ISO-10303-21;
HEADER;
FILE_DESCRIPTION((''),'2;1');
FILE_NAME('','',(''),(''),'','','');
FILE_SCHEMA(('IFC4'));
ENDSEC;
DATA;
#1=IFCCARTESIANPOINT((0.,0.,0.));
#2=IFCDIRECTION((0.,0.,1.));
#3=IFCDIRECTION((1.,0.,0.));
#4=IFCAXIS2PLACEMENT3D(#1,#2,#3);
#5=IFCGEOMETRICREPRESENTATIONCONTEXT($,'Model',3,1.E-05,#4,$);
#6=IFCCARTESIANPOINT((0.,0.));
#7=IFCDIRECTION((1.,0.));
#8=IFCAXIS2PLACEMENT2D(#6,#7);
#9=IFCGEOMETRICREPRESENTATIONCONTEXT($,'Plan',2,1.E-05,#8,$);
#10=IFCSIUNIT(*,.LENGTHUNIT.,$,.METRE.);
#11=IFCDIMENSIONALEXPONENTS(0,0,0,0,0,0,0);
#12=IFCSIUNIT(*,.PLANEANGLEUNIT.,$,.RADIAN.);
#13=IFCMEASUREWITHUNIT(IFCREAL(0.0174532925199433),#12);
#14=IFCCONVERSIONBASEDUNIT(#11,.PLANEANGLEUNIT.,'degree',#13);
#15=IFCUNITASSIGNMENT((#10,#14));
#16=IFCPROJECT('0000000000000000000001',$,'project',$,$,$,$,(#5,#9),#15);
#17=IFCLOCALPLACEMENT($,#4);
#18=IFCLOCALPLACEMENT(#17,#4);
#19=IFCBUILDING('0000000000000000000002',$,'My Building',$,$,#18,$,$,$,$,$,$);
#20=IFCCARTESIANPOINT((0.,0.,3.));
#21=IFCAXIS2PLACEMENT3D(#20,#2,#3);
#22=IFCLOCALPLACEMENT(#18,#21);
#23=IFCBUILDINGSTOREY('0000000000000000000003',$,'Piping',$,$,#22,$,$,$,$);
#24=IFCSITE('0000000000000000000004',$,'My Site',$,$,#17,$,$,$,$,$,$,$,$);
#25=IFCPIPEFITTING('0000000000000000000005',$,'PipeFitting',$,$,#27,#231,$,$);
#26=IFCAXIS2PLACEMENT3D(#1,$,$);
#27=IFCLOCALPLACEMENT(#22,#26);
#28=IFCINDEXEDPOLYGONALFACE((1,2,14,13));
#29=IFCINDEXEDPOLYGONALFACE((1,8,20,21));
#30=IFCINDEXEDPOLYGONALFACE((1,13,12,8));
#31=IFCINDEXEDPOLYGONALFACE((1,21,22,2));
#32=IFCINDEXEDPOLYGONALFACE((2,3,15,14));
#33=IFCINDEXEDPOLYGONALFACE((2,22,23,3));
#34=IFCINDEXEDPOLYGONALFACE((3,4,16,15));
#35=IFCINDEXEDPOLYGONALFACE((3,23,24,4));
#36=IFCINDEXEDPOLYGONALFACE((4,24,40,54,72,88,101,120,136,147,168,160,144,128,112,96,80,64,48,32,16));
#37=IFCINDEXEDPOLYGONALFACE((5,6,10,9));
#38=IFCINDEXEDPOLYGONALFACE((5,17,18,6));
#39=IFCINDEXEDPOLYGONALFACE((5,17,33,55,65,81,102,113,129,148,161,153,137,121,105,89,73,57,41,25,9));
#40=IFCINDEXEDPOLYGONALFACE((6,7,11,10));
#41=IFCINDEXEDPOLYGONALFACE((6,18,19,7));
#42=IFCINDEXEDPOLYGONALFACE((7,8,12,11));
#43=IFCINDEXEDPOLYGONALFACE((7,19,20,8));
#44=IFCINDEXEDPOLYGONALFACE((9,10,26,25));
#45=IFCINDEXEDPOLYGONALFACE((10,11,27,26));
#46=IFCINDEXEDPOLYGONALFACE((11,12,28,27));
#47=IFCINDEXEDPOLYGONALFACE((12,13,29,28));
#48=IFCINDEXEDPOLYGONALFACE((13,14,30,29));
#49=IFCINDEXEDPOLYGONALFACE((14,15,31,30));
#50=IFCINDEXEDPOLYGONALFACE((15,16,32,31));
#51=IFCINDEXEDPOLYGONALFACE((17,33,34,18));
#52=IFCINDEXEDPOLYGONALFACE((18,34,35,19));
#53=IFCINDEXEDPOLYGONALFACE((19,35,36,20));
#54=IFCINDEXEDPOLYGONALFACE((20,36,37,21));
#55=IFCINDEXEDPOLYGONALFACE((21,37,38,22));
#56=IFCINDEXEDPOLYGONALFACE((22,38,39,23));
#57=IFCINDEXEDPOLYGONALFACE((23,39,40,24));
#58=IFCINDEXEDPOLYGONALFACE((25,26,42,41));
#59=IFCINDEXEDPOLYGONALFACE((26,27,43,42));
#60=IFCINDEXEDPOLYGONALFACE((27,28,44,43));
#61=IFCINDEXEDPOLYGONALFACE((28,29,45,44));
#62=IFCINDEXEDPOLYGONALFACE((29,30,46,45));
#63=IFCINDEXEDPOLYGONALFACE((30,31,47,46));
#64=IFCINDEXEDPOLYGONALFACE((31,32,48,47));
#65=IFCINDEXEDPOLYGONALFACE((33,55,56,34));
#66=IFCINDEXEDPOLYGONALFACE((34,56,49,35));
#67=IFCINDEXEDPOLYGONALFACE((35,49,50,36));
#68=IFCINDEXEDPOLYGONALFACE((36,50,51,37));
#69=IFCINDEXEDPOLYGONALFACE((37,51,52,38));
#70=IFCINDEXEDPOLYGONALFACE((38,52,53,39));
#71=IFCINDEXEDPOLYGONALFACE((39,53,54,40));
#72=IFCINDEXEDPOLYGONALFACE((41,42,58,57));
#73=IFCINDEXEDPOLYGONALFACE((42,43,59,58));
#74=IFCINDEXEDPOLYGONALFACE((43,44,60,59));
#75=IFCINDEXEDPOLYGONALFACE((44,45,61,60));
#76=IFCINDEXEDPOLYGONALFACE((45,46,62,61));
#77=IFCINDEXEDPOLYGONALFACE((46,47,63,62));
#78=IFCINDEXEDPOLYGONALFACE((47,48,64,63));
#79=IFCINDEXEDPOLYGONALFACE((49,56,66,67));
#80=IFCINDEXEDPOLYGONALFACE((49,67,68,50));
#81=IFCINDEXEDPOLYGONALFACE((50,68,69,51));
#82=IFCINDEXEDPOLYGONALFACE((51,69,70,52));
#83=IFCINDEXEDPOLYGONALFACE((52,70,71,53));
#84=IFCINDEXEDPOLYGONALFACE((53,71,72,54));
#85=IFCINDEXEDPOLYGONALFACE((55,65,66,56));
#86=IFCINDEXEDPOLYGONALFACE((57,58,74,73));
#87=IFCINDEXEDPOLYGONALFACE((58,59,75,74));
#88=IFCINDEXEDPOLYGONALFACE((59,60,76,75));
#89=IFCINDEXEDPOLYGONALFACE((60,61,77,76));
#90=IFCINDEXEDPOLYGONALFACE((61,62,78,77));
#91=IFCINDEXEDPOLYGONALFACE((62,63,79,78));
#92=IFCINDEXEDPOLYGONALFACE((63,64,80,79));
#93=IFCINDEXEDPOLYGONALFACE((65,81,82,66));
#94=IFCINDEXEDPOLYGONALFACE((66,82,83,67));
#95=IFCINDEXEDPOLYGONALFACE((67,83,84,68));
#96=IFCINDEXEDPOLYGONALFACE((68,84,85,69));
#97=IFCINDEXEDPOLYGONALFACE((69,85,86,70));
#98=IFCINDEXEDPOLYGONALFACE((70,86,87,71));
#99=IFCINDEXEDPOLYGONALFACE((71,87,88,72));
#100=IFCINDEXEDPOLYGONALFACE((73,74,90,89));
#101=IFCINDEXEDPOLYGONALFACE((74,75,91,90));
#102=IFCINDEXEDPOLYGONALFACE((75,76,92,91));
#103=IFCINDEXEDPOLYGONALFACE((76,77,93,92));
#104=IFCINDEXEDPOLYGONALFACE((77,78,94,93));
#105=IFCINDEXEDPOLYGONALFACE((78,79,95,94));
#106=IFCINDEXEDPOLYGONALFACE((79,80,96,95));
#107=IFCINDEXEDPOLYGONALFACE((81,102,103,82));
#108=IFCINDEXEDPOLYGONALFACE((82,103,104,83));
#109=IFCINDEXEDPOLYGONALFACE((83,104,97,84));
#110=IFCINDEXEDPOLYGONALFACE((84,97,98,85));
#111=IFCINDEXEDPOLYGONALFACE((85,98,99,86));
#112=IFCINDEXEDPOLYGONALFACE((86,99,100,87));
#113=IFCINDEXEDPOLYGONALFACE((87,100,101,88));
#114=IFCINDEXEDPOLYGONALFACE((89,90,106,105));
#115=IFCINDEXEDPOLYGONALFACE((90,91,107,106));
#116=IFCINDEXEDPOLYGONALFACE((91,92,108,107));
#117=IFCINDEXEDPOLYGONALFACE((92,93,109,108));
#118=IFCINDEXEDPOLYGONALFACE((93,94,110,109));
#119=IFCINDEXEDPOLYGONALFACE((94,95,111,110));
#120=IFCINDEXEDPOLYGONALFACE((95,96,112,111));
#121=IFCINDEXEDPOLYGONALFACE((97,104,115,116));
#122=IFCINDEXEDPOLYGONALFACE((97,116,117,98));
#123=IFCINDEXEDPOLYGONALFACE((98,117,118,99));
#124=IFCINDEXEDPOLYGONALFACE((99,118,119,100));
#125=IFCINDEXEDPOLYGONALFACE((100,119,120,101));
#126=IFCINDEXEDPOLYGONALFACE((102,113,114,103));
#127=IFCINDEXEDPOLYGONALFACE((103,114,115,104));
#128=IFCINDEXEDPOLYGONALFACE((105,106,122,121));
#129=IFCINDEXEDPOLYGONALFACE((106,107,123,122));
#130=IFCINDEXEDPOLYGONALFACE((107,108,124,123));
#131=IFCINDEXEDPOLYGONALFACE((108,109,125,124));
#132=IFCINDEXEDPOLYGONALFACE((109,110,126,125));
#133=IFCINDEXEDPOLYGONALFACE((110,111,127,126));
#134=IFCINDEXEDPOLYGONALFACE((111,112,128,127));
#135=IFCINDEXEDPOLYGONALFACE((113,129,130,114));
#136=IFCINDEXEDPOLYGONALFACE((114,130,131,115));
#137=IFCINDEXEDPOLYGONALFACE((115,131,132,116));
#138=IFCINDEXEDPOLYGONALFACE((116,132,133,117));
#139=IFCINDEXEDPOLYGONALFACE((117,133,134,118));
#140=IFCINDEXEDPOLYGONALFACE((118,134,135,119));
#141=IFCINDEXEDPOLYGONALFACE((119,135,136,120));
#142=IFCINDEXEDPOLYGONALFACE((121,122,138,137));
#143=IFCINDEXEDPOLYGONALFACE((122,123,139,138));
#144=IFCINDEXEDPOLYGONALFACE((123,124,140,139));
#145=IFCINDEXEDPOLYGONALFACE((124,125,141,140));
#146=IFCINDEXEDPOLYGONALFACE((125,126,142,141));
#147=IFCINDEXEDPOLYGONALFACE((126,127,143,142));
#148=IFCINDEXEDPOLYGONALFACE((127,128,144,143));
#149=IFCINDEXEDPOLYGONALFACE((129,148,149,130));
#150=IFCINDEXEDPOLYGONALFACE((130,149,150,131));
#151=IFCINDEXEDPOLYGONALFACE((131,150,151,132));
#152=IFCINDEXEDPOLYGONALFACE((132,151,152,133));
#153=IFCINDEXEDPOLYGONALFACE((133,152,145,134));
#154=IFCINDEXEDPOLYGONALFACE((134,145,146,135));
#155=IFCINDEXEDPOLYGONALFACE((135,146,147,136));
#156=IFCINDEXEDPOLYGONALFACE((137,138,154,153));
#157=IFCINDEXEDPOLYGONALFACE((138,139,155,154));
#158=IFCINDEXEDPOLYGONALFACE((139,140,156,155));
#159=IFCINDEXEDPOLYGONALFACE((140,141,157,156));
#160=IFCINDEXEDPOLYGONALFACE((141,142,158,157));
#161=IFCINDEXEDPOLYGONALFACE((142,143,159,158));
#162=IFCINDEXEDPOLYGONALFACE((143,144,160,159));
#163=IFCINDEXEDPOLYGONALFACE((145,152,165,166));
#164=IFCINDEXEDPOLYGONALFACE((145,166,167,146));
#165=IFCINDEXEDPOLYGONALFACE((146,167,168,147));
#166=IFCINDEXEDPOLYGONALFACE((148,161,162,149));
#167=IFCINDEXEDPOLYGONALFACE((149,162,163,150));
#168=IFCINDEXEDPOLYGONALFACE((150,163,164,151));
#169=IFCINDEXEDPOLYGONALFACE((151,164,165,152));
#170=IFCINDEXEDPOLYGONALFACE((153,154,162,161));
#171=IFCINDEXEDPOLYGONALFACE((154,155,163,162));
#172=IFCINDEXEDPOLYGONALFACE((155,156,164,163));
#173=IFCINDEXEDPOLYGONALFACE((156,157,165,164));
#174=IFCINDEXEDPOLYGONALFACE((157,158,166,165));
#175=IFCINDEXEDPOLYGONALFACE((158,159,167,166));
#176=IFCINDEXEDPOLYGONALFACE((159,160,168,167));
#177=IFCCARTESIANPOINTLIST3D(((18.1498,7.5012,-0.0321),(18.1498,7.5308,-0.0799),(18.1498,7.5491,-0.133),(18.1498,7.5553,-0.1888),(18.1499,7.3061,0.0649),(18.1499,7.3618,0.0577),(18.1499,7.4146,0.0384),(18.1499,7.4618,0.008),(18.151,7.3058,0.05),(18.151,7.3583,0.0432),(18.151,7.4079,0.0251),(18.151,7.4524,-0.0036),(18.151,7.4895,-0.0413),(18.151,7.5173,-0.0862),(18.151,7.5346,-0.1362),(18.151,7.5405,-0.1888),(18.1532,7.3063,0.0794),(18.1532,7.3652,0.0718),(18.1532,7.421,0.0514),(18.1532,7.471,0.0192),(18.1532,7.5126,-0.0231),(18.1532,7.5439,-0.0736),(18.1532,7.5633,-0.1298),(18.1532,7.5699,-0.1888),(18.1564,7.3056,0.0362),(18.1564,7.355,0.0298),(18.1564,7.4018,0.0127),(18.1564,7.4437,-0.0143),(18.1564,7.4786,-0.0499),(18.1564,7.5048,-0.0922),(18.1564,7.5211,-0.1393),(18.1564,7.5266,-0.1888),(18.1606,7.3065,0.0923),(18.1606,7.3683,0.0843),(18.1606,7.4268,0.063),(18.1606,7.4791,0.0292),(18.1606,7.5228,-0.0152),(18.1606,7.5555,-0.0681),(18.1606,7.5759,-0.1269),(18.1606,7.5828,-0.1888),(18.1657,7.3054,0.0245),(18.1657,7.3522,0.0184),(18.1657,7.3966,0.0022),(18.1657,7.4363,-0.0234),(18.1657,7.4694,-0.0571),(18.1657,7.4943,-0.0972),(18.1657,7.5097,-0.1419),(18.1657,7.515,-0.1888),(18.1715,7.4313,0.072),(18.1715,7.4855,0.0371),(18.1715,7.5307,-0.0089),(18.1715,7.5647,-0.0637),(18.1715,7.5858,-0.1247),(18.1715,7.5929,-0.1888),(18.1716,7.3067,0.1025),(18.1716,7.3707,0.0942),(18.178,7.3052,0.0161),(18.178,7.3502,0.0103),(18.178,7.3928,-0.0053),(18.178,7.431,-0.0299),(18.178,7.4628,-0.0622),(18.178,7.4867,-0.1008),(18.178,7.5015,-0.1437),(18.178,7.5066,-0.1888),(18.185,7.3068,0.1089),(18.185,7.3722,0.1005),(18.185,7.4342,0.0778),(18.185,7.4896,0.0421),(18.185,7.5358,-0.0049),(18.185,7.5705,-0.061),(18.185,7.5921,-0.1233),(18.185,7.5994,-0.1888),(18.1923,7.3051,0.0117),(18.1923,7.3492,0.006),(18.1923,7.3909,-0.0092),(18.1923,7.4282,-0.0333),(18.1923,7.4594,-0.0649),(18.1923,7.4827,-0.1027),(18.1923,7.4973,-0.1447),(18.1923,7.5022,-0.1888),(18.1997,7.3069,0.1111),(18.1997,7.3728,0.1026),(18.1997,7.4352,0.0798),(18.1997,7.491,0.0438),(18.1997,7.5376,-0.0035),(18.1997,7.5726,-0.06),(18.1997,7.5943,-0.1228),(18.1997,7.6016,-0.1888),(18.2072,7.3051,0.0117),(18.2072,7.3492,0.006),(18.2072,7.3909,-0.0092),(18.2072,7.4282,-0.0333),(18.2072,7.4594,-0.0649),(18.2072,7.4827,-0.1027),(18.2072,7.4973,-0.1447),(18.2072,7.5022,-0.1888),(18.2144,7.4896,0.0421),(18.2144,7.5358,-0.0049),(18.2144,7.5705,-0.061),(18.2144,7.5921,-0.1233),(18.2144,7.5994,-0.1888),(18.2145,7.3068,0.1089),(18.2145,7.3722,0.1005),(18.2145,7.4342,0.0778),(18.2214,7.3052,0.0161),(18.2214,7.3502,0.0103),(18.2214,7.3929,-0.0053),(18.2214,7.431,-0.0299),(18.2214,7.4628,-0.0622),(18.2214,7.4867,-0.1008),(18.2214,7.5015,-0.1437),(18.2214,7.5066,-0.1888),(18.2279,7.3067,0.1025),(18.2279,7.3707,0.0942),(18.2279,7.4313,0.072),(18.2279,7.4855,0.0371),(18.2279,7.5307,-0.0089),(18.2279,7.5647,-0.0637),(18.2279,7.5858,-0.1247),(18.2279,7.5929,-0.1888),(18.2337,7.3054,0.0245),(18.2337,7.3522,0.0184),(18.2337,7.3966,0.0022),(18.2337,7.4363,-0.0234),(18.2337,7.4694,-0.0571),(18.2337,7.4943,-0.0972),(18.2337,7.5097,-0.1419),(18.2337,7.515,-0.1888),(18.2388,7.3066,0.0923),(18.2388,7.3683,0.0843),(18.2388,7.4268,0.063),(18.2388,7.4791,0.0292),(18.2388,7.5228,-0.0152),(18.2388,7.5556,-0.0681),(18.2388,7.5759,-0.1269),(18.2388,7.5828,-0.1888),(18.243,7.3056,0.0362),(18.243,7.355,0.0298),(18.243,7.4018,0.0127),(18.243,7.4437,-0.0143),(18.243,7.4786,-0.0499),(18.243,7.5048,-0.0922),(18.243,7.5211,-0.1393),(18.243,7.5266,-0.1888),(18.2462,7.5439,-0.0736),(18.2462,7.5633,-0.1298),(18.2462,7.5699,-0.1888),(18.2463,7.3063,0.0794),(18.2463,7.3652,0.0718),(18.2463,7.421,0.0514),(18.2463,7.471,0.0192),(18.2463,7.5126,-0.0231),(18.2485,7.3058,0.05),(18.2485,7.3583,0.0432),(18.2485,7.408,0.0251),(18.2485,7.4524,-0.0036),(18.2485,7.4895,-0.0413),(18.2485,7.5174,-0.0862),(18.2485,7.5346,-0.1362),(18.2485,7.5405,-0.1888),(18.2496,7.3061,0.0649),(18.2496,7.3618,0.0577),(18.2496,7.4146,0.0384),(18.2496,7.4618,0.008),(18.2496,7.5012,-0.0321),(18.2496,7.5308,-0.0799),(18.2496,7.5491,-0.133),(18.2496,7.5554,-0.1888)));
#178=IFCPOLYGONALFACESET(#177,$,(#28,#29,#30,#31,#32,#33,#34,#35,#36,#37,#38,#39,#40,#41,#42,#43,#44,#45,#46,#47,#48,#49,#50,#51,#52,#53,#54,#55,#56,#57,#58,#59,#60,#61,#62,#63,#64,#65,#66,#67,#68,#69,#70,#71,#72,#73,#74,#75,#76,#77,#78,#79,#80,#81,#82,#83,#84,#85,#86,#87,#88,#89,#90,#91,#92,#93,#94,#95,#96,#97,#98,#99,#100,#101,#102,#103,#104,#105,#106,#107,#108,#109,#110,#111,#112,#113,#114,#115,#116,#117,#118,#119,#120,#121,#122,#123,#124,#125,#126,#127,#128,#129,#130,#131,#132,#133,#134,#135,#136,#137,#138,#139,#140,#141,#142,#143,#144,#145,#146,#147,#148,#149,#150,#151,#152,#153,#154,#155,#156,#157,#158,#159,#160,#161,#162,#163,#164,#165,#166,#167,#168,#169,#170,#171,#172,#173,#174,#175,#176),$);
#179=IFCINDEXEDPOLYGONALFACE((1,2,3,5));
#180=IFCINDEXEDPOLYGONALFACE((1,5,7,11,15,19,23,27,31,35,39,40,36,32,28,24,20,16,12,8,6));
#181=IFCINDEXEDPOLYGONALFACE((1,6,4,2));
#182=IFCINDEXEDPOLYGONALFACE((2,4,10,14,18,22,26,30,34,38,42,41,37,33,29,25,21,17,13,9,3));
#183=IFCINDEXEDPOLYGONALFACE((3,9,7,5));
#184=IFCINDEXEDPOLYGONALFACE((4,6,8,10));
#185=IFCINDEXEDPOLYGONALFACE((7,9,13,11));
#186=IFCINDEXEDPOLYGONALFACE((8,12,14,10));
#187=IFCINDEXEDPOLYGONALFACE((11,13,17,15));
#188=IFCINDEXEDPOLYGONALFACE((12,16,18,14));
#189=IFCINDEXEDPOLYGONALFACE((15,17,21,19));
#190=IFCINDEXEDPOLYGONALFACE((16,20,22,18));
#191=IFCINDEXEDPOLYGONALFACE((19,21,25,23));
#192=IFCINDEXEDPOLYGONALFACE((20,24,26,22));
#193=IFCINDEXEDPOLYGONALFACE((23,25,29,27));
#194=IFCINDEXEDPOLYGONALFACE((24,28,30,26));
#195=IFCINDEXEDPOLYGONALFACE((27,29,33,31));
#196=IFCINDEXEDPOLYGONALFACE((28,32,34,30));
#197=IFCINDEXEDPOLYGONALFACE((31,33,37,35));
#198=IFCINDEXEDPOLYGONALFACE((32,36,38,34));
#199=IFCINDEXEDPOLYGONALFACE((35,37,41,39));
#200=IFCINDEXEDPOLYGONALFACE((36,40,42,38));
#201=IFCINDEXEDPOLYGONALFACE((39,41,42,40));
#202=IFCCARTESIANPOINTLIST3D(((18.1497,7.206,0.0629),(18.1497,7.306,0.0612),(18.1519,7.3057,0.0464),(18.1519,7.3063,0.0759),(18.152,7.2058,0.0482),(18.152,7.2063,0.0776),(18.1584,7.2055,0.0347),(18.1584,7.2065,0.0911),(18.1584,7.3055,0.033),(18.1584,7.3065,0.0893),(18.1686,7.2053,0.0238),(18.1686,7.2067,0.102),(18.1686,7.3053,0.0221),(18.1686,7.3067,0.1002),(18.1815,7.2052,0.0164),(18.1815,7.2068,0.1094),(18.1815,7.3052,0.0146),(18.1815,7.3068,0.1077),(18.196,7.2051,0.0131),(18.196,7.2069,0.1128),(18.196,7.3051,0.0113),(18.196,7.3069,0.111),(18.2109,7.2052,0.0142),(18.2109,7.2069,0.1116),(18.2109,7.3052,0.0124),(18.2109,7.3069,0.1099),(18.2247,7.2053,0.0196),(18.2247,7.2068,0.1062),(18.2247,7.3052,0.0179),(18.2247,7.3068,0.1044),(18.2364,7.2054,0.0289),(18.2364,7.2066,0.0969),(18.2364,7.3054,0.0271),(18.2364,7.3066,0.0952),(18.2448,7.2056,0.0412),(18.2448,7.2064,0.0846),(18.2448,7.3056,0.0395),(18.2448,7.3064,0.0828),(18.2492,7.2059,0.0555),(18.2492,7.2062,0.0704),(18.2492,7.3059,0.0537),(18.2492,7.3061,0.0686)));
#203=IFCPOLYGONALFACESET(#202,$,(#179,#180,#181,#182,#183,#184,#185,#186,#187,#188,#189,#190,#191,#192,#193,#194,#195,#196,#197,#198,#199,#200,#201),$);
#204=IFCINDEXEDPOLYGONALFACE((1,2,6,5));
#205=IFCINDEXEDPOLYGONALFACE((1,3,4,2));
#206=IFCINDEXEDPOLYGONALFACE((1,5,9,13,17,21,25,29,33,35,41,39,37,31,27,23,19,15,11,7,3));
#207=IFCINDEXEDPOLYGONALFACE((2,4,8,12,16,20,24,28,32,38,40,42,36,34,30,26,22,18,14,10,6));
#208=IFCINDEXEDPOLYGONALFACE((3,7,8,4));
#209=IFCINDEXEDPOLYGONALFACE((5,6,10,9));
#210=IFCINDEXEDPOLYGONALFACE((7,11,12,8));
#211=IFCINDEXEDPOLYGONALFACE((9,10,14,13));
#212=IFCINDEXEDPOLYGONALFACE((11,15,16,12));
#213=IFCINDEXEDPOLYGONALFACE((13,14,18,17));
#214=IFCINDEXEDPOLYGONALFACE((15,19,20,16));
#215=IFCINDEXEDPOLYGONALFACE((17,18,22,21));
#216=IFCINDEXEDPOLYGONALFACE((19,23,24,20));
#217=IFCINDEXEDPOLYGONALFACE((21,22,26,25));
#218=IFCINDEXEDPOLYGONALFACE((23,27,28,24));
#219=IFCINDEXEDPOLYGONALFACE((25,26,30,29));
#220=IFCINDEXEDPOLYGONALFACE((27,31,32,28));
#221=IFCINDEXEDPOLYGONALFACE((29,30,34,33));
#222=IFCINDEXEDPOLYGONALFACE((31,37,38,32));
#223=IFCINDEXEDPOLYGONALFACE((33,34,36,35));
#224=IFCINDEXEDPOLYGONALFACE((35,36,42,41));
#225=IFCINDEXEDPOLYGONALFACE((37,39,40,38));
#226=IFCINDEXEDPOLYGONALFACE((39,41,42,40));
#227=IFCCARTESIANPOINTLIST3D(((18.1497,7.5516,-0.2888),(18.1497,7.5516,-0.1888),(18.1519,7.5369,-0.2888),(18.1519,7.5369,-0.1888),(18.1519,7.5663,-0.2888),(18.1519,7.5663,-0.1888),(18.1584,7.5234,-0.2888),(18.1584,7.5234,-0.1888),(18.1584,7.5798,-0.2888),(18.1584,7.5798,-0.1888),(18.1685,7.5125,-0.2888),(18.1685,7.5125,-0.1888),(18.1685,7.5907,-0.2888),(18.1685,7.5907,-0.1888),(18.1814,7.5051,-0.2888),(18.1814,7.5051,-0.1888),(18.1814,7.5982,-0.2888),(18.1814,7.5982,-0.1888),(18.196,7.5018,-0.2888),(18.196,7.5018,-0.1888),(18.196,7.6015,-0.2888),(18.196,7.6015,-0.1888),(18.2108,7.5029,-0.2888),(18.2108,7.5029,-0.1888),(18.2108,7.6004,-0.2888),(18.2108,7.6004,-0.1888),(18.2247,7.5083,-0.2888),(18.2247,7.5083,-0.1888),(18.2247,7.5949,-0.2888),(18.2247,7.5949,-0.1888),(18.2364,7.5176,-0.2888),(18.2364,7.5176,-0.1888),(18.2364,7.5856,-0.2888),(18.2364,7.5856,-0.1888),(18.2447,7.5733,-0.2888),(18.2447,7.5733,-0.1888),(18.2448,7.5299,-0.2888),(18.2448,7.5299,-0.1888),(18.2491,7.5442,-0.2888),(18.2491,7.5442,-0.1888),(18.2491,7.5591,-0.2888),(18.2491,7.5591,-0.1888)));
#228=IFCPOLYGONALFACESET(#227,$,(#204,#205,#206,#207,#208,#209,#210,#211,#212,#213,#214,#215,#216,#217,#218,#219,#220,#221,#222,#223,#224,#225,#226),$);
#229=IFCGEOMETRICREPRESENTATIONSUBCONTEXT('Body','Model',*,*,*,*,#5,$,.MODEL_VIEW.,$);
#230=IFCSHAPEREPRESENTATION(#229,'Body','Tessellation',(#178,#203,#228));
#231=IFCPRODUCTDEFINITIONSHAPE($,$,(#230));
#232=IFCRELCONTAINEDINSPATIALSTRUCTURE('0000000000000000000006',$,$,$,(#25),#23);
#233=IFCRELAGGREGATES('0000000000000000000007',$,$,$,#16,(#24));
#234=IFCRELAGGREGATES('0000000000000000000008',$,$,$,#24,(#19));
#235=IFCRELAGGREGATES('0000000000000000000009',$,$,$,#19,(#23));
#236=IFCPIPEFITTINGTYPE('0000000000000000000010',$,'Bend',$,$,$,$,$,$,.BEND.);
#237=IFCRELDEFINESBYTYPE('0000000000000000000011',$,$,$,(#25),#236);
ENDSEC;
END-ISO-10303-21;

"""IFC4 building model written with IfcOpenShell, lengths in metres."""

from ifc_helpers import new_model, entity, si_unit, converted_unit, frame, origin_with_axes, origin_2d_with_axis, place, context, subcontext, project, spatial, circle, extrude, source, transform, mapped, type_object, type_shapes, element, save


model = new_model("IFC4")

# Units and contexts
model_context = context("Model", 3, precision=1e-05, world=origin_with_axes())
plan_context = context("Plan", 2, precision=1e-05, world=origin_2d_with_axis())
body_context = subcontext(model_context, "Body", "Model", "MODEL_VIEW")
ifc_project = project(units=[si_unit("LENGTHUNIT", "METRE"), converted_unit("PLANEANGLEUNIT", "degree", entity("IfcReal", 0.0174532925199433), si_unit("PLANEANGLEUNIT", "RADIAN"), dimensions=[0, 0, 0, 0, 0, 0, 0])], contexts=[model_context, plan_context])

# Site, building, storey
site_placement = place(None, origin_with_axes())
site = spatial("IfcSite", under=ifc_project, at=site_placement, Name="My Site")
building_placement = place(site_placement, origin_with_axes())
building = spatial("IfcBuilding", under=site, at=building_placement, Name="My Building")
storey_placement = place(building_placement, frame((0.0, 0.0, 3.0), z_axis=(0.0, 0.0, 1.0), x_axis=(1.0, 0.0, 0.0)))
storey = spatial("IfcBuildingStorey", under=building, at=storey_placement, Name="Piping")

# Pipe fitting
pipe_fitting_type_1 = type_object("IfcPipeFittingType", Name="Bend", PredefinedType="BEND")
shared_shape_1 = source(origin_with_axes(), body_context, "Body", "SolidModel", [
    entity("IfcSweptDiskSolid", entity("IfcIndexedPolyCurve", entity("IfcCartesianPointList3D", [[0.0, 0.0, 0.1], [0.0, -0.0717, 0.2752], [0.0, -0.2456, 0.35]]), [entity("IfcArcIndex", [1, 2, 3])]), 0.05),
    extrude(circle(Radius=0.05), origin_with_axes(), (0.0, 0.0, 1.0), 0.1),
    extrude(circle(Radius=0.05), frame((0.0, -0.2456, 0.35), z_axis=(0.0, -0.999846, 0.017575), x_axis=(1.0, 0.0, 0.0)), (0.0, 0.0, 1.0), 0.1),
])
type_shapes(pipe_fitting_type_1, [shared_shape_1])
for number, where, z_axis, x_axis, name in (
    (1, (18.1997, 7.206, 0.0629), (-0.000099, 0.999846, -0.017575), (-1.0, -0.000099, 0.0), "PipeFitting"),
):
    element("IfcPipeFitting", number, at=place(storey_placement, frame(where, z_axis=z_axis, x_axis=x_axis)), inside=storey, type_object=pipe_fitting_type_1, Name=name, context=body_context, shape_type="MappedRepresentation", body=[
        mapped(shared_shape_1, transform((0.0, 0.0, 0.0), x_axis=(1.0, 0.0, 0.0), y_axis=(0.0, 1.0, 0.0), z_axis=(0.0, 0.0, 1.0), scale=1.0)),
    ])

save(model, "model.ifc")
